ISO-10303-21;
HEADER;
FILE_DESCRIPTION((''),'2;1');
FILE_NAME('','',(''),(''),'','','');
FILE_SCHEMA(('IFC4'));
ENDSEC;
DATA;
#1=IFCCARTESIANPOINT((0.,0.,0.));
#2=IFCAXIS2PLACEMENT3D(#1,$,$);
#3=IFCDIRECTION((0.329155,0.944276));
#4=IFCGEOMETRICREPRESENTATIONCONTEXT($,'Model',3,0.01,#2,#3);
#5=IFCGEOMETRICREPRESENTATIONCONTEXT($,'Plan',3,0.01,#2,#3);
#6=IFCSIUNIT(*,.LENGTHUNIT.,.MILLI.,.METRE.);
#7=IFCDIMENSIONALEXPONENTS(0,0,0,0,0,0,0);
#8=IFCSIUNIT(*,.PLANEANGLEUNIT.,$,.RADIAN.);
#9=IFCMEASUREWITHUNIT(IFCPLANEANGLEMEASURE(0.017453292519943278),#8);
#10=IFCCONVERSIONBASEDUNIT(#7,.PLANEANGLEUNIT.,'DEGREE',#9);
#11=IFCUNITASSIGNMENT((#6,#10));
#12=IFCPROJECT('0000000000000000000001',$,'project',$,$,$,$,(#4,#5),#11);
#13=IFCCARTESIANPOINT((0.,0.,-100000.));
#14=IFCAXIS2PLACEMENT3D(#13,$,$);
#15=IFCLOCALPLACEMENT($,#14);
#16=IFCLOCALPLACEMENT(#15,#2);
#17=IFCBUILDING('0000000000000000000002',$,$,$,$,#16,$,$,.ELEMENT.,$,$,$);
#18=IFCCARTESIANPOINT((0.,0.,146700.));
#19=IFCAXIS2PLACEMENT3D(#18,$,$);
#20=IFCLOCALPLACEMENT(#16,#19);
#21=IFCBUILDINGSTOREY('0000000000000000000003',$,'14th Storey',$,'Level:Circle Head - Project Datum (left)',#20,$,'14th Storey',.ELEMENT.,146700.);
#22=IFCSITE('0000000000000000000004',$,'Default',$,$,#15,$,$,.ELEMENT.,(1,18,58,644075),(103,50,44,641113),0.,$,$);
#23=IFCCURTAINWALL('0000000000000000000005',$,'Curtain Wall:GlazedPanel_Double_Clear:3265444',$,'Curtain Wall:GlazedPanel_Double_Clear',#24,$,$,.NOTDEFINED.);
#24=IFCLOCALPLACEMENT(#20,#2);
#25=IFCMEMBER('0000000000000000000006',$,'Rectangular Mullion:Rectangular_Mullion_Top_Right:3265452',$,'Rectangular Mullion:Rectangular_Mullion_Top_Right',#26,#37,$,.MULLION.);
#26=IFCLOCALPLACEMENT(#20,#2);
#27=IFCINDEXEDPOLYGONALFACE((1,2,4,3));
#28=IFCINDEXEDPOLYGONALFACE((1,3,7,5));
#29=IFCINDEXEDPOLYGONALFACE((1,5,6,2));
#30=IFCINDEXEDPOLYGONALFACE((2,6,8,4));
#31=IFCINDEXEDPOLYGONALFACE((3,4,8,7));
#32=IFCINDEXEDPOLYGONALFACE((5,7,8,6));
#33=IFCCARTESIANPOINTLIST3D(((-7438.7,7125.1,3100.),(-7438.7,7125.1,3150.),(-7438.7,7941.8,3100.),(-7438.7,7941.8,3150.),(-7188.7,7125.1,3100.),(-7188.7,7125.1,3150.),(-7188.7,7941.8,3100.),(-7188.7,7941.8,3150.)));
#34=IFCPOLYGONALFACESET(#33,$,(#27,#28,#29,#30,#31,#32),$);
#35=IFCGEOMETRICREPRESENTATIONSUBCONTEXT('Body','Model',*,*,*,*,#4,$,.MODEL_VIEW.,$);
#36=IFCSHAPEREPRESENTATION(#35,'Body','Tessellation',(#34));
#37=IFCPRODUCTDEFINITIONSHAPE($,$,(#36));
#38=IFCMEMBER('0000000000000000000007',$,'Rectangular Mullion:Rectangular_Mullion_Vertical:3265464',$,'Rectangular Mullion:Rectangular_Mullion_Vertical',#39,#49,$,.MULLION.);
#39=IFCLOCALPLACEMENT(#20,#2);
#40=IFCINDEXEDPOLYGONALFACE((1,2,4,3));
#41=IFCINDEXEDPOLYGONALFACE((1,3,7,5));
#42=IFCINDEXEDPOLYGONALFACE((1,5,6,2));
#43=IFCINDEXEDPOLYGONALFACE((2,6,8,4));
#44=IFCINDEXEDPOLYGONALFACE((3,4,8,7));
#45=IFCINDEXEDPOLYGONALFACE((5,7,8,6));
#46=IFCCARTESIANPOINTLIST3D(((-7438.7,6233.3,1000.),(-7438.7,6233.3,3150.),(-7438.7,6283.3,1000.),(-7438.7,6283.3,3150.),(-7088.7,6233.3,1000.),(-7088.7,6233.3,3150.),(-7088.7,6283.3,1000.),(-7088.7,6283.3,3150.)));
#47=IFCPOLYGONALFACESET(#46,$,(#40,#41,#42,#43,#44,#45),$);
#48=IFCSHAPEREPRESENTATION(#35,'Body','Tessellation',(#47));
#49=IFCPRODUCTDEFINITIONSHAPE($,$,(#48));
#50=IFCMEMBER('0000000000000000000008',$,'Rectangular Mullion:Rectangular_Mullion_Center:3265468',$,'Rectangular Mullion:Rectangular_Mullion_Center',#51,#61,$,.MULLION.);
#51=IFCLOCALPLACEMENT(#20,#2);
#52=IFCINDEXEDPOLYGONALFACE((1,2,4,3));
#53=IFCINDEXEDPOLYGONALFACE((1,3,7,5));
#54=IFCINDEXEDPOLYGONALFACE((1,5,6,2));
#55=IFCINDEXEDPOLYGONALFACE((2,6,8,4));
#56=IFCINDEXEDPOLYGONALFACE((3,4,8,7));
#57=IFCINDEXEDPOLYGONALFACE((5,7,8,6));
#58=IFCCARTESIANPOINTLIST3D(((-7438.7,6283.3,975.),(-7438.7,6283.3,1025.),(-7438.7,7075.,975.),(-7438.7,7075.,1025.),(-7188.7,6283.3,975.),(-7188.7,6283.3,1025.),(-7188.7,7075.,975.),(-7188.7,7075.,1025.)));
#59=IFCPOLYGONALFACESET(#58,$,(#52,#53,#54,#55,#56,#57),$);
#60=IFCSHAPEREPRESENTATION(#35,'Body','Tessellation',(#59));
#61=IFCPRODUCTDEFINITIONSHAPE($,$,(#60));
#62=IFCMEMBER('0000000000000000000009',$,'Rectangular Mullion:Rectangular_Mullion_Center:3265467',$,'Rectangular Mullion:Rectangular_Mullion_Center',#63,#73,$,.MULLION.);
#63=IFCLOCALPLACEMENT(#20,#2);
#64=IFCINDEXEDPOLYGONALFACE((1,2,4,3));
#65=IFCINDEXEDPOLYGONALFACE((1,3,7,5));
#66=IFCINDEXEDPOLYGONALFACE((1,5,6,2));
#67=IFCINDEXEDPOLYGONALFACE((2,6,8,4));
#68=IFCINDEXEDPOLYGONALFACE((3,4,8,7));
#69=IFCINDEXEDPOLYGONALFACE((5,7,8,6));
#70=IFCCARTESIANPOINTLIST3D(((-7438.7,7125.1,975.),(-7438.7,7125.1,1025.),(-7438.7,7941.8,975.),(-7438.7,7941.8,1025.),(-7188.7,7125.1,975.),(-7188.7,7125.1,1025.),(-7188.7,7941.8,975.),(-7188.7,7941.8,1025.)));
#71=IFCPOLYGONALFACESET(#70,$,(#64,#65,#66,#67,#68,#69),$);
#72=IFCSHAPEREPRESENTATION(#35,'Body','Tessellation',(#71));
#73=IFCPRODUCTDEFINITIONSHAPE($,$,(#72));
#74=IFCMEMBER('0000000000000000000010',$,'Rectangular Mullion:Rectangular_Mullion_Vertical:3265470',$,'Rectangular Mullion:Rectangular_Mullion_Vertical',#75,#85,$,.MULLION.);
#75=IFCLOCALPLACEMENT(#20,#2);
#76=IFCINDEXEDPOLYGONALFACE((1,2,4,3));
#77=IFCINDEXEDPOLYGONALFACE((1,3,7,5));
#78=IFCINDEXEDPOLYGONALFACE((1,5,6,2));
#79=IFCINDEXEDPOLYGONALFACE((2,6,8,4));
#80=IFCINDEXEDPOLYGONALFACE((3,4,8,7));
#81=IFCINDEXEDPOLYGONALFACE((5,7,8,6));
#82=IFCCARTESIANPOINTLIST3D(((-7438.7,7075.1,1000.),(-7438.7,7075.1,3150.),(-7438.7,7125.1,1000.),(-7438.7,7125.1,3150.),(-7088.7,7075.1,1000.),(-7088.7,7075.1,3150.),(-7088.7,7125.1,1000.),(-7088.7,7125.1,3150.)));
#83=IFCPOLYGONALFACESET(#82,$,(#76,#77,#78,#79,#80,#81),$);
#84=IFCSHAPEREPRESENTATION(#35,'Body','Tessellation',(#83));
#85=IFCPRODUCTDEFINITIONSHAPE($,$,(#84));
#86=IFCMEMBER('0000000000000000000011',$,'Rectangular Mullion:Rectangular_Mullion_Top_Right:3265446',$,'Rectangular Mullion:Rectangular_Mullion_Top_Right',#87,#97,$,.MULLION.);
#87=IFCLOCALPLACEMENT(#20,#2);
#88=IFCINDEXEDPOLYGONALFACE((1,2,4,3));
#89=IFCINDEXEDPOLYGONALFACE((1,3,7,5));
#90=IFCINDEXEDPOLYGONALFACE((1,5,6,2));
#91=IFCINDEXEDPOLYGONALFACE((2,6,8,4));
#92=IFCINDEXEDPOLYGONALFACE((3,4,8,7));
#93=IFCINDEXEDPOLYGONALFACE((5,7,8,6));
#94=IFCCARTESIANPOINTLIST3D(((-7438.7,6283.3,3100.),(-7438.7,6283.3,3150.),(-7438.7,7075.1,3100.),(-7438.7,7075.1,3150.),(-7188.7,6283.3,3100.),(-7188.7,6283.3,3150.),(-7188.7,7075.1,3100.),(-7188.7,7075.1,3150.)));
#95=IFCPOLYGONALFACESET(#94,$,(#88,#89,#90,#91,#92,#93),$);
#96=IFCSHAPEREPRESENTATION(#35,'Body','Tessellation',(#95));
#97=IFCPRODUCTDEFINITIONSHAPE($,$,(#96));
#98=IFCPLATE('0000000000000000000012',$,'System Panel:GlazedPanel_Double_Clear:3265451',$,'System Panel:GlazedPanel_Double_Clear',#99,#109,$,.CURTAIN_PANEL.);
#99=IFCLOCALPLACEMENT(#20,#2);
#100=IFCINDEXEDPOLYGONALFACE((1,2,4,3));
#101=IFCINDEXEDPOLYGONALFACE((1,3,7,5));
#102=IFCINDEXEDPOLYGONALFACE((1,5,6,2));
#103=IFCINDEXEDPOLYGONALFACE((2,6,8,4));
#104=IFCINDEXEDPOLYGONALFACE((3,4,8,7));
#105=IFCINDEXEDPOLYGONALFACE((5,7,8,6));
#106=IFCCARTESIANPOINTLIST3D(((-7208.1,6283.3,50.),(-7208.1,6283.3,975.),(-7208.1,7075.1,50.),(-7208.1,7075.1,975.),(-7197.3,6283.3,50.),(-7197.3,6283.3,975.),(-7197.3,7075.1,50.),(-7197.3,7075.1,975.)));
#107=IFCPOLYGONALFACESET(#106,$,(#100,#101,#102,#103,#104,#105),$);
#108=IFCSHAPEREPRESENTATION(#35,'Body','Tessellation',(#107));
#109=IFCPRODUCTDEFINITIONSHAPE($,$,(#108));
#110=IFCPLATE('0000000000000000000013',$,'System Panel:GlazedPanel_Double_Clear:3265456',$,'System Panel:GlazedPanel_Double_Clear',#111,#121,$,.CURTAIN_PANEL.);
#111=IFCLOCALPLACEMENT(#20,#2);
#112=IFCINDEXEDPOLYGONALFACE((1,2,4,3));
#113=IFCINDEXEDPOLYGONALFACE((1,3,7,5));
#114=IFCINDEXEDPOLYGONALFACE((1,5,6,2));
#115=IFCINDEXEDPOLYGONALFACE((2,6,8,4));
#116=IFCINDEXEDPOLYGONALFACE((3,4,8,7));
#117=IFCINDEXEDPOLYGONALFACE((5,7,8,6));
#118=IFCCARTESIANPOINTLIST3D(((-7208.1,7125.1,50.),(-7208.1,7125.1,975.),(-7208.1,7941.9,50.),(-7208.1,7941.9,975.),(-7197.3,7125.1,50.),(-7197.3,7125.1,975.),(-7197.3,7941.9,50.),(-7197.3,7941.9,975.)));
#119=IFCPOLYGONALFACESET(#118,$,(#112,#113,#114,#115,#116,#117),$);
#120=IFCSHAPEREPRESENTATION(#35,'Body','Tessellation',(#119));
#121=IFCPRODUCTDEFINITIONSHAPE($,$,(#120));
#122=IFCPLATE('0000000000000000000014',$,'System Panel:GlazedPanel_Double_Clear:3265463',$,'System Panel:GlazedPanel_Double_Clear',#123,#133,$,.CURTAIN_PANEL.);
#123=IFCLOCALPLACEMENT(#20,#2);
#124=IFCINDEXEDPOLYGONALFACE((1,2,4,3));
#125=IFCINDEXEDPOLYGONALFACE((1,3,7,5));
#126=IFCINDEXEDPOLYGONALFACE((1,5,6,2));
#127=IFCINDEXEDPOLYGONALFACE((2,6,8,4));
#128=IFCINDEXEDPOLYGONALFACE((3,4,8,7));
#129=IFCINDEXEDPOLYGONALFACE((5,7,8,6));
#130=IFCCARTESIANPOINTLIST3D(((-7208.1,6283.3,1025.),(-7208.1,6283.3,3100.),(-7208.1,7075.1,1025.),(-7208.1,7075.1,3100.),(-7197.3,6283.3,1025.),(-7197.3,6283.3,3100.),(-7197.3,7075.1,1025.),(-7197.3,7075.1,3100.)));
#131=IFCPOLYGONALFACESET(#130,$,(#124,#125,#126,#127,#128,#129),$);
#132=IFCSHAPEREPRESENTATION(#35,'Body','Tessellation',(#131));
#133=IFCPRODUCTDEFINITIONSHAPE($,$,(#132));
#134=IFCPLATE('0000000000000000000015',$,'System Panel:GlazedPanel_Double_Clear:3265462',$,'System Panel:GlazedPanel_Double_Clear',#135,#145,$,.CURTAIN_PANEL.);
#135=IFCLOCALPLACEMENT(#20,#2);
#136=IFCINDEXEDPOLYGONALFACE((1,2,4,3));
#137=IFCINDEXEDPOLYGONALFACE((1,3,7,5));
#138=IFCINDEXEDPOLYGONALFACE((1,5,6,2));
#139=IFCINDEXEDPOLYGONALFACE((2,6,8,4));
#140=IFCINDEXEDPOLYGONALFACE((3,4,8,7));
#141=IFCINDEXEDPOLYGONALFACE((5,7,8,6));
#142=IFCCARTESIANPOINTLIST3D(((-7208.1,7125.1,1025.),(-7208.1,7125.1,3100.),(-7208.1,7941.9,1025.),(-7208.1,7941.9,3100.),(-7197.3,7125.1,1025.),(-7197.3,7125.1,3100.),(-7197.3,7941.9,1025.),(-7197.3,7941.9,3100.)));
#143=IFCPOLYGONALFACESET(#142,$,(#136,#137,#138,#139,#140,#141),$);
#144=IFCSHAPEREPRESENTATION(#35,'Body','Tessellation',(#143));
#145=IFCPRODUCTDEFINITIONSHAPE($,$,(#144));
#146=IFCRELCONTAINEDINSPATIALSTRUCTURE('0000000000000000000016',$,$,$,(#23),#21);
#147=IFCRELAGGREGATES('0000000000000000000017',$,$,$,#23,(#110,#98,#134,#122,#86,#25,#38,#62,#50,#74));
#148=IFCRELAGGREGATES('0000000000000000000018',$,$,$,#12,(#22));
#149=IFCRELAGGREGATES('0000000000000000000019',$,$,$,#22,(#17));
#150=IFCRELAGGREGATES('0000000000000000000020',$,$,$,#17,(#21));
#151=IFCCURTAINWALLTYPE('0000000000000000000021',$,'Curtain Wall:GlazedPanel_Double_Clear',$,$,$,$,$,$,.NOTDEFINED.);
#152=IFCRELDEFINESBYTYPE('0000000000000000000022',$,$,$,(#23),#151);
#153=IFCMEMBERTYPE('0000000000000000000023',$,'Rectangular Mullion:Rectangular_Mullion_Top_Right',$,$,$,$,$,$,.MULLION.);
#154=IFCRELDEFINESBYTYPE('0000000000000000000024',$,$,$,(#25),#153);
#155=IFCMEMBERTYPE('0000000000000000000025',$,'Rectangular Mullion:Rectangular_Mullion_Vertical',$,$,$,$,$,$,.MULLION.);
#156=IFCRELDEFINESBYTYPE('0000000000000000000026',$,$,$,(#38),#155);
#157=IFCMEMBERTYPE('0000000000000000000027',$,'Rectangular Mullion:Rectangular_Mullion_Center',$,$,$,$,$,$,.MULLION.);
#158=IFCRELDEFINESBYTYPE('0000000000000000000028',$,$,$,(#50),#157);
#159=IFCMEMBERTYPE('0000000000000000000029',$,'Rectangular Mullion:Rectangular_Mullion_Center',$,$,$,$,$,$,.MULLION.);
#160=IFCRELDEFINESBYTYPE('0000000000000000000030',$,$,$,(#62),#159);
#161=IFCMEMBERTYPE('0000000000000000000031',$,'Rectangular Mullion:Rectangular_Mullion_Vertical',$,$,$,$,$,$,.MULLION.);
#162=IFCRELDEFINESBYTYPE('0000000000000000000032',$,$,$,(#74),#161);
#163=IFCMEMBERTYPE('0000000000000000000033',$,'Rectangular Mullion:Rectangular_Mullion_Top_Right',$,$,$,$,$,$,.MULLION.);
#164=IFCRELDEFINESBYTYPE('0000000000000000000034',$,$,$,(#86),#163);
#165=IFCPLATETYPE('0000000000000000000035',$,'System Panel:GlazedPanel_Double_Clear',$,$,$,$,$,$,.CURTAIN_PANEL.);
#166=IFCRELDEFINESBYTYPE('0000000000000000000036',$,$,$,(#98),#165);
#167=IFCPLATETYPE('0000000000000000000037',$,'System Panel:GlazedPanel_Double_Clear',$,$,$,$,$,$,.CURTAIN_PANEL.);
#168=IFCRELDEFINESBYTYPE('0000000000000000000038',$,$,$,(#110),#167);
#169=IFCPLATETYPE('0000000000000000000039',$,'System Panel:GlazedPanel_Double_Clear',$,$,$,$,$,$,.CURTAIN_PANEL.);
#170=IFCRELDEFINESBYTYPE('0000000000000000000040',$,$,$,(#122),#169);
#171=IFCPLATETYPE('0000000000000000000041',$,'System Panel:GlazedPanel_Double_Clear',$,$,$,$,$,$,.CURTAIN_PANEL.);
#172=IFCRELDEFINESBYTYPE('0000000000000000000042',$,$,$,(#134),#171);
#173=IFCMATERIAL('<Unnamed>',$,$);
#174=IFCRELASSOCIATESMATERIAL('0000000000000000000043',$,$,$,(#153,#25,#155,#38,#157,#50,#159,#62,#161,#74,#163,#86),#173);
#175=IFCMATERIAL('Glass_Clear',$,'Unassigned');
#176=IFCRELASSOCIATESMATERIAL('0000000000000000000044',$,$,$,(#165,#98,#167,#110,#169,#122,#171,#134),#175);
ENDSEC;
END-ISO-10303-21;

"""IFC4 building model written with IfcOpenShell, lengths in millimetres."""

from ifc_helpers import new_model, entity, si_unit, converted_unit, direction, frame, origin, place, context, subcontext, project, spatial, indexed_curve, outline, extrude, source, transform, mapped, material, type_object, type_shapes, element, aggregate, save


model = new_model("IFC4")

# Units and contexts
model_context = context("Model", 3, precision=0.01, world=origin(), true_north=direction((0.329155, 0.944276)))
plan_context = context("Plan", 3, precision=0.01, world=origin(), true_north=direction((0.329155, 0.944276)))
body_context = subcontext(model_context, "Body", "Model", "MODEL_VIEW")
ifc_project = project(units=[si_unit("LENGTHUNIT", "METRE", prefix="MILLI"), converted_unit("PLANEANGLEUNIT", "DEGREE", entity("IfcPlaneAngleMeasure", 0.017453292519943278), si_unit("PLANEANGLEUNIT", "RADIAN"), dimensions=[0, 0, 0, 0, 0, 0, 0])], contexts=[model_context, plan_context])

# Site, building, storey
site_placement = place(None, frame((0.0, 0.0, -100000.0)))
site = spatial("IfcSite", under=ifc_project, at=site_placement, Name="Default", CompositionType="ELEMENT", RefLatitude=(1, 18, 58, 644075), RefLongitude=(103, 50, 44, 641113), RefElevation=0.0)
building_placement = place(site_placement, origin())
building = spatial("IfcBuilding", under=site, at=building_placement, CompositionType="ELEMENT")
storey_placement = place(building_placement, frame((0.0, 0.0, 146700.0)))
storey = spatial("IfcBuildingStorey", under=building, at=storey_placement, Name="14th Storey", ObjectType="Level:Circle Head - Project Datum (left)", LongName="14th Storey", CompositionType="ELEMENT", Elevation=146700.0)

# Curtain wall, members, plates
curtain_wall_type = type_object("IfcCurtainWallType", Name="Curtain Wall:GlazedPanel_Double_Clear", PredefinedType="NOTDEFINED")
curtain_wall_placement = place(storey_placement, frame((0.0, 0.0, -146700.0)))
curtain_wall = element("IfcCurtainWall", 1, at=curtain_wall_placement, inside=storey, type_object=curtain_wall_type, Name="Curtain Wall:GlazedPanel_Double_Clear:3265444", ObjectType="Curtain Wall:GlazedPanel_Double_Clear", PredefinedType="NOTDEFINED")
ifc_material_1 = material(Name="<Unnamed>")
member_type_1 = type_object("IfcMemberType", Name="Rectangular Mullion:Rectangular_Mullion_Top_Right", PredefinedType="MULLION", material=ifc_material_1)
shared_shape_1 = source(origin(), body_context, "Body", "SweptSolid", [
    extrude(outline(indexed_curve([(-25.0, -125.0), (25.0, -125.0), (25.0, 125.0), (-25.0, 125.0), (-25.0, -125.0)], self_intersect=False)), frame((-25.0, 0.0, -816.7), z_axis=(0.0, 0.0, 1.0), x_axis=(-1.0, 0.0, 0.0)), (0.0, 0.0, 1.0), 816.7),
])
type_shapes(member_type_1, [shared_shape_1])
member_1_placement = place(curtain_wall_placement, frame((-7313.7, 7125.1, 149850.0), z_axis=(0.0, -1.0, 0.0), x_axis=(0.0, 0.0, 1.0)))
member_1 = element("IfcMember", 2, at=member_1_placement, type_object=member_type_1, material=ifc_material_1, Name="Rectangular Mullion:Rectangular_Mullion_Top_Right:3265452", ObjectType="Rectangular Mullion:Rectangular_Mullion_Top_Right", PredefinedType="MULLION", context=body_context, shape_type="MappedRepresentation", body=[
    mapped(shared_shape_1, transform((0.0, 0.0, 0.0), scale=1.0)),
])
member_type_2 = type_object("IfcMemberType", Name="Rectangular Mullion:Rectangular_Mullion_Vertical", PredefinedType="MULLION", material=ifc_material_1)
shared_shape_2 = source(origin(), body_context, "Body", "SweptSolid", [
    extrude(outline(indexed_curve([(-25.0, -175.0), (25.0, -175.0), (25.0, 175.0), (-25.0, 175.0), (-25.0, -175.0)], self_intersect=False)), frame((-25.0, -50.0, -2150.0), z_axis=(0.0, 0.0, 1.0), x_axis=(-1.0, 0.0, 0.0)), (0.0, 0.0, 1.0), 2150.0),
])
type_shapes(member_type_2, [shared_shape_2])
member_2_placement = place(curtain_wall_placement, frame((-7313.7, 6233.3, 147700.0), z_axis=(0.0, 0.0, -1.0), x_axis=(0.0, -1.0, 0.0)))
member_2 = element("IfcMember", 3, at=member_2_placement, type_object=member_type_2, material=ifc_material_1, Name="Rectangular Mullion:Rectangular_Mullion_Vertical:3265464", ObjectType="Rectangular Mullion:Rectangular_Mullion_Vertical", PredefinedType="MULLION", context=body_context, shape_type="MappedRepresentation", body=[
    mapped(shared_shape_2, transform((0.0, 0.0, 0.0), scale=1.0)),
])
member_type_3 = type_object("IfcMemberType", Name="Rectangular Mullion:Rectangular_Mullion_Center", PredefinedType="MULLION", material=ifc_material_1)
shared_shape_3 = source(origin(), body_context, "Body", "SweptSolid", [
    extrude(outline(indexed_curve([(-25.0, -125.0), (25.0, -125.0), (25.0, 125.0), (-25.0, 125.0), (-25.0, -125.0)], self_intersect=False)), frame((0.0, 0.0, -791.7), z_axis=(0.0, 0.0, 1.0), x_axis=(-1.0, 0.0, 0.0)), (0.0, 0.0, 1.0), 791.7),
])
type_shapes(member_type_3, [shared_shape_3])
member_3_placement = place(curtain_wall_placement, frame((-7313.7, 6283.3, 147700.0), z_axis=(0.0, -1.0, 0.0), x_axis=(0.0, 0.0, 1.0)))
member_3 = element("IfcMember", 4, at=member_3_placement, type_object=member_type_3, material=ifc_material_1, Name="Rectangular Mullion:Rectangular_Mullion_Center:3265468", ObjectType="Rectangular Mullion:Rectangular_Mullion_Center", PredefinedType="MULLION", context=body_context, shape_type="MappedRepresentation", body=[
    mapped(shared_shape_3, transform((0.0, 0.0, 0.0), scale=1.0)),
])
member_type_4 = type_object("IfcMemberType", Name="Rectangular Mullion:Rectangular_Mullion_Center", PredefinedType="MULLION", material=ifc_material_1)
shared_shape_4 = source(origin(), body_context, "Body", "SweptSolid", [
    extrude(outline(indexed_curve([(-25.0, -125.0), (25.0, -125.0), (25.0, 125.0), (-25.0, 125.0), (-25.0, -125.0)], self_intersect=False)), frame((0.0, 0.0, -816.7), z_axis=(0.0, 0.0, 1.0), x_axis=(-1.0, 0.0, 0.0)), (0.0, 0.0, 1.0), 816.7),
])
type_shapes(member_type_4, [shared_shape_4])
member_4_placement = place(curtain_wall_placement, frame((-7313.7, 7125.1, 147700.0), z_axis=(0.0, -1.0, 0.0), x_axis=(0.0, 0.0, 1.0)))
member_4 = element("IfcMember", 5, at=member_4_placement, type_object=member_type_4, material=ifc_material_1, Name="Rectangular Mullion:Rectangular_Mullion_Center:3265467", ObjectType="Rectangular Mullion:Rectangular_Mullion_Center", PredefinedType="MULLION", context=body_context, shape_type="MappedRepresentation", body=[
    mapped(shared_shape_4, transform((0.0, 0.0, 0.0), scale=1.0)),
])
member_type_5 = type_object("IfcMemberType", Name="Rectangular Mullion:Rectangular_Mullion_Vertical", PredefinedType="MULLION", material=ifc_material_1)
shared_shape_5 = source(origin(), body_context, "Body", "SweptSolid", [
    extrude(outline(indexed_curve([(-25.0, -175.0), (25.0, -175.0), (25.0, 175.0), (-25.0, 175.0), (-25.0, -175.0)], self_intersect=False)), frame((0.0, -50.0, -2150.0), z_axis=(0.0, 0.0, 1.0), x_axis=(-1.0, 0.0, 0.0)), (0.0, 0.0, 1.0), 2150.0),
])
type_shapes(member_type_5, [shared_shape_5])
member_5_placement = place(curtain_wall_placement, frame((-7313.7, 7100.1, 147700.0), z_axis=(0.0, 0.0, -1.0), x_axis=(0.0, -1.0, 0.0)))
member_5 = element("IfcMember", 6, at=member_5_placement, type_object=member_type_5, material=ifc_material_1, Name="Rectangular Mullion:Rectangular_Mullion_Vertical:3265470", ObjectType="Rectangular Mullion:Rectangular_Mullion_Vertical", PredefinedType="MULLION", context=body_context, shape_type="MappedRepresentation", body=[
    mapped(shared_shape_5, transform((0.0, 0.0, 0.0), scale=1.0)),
])
member_type_6 = type_object("IfcMemberType", Name="Rectangular Mullion:Rectangular_Mullion_Top_Right", PredefinedType="MULLION", material=ifc_material_1)
shared_shape_6 = source(origin(), body_context, "Body", "SweptSolid", [
    extrude(outline(indexed_curve([(-25.0, -125.0), (25.0, -125.0), (25.0, 125.0), (-25.0, 125.0), (-25.0, -125.0)], self_intersect=False)), frame((-25.0, 0.0, -791.8), z_axis=(0.0, 0.0, 1.0), x_axis=(-1.0, 0.0, 0.0)), (0.0, 0.0, 1.0), 791.8),
])
type_shapes(member_type_6, [shared_shape_6])
member_6_placement = place(curtain_wall_placement, frame((-7313.7, 6283.3, 149850.0), z_axis=(0.0, -1.0, 0.0), x_axis=(0.0, 0.0, 1.0)))
member_6 = element("IfcMember", 7, at=member_6_placement, type_object=member_type_6, material=ifc_material_1, Name="Rectangular Mullion:Rectangular_Mullion_Top_Right:3265446", ObjectType="Rectangular Mullion:Rectangular_Mullion_Top_Right", PredefinedType="MULLION", context=body_context, shape_type="MappedRepresentation", body=[
    mapped(shared_shape_6, transform((0.0, 0.0, 0.0), scale=1.0)),
])
ifc_material_2 = material(Name="Glass_Clear", Category="Unassigned")
plate_type_1 = type_object("IfcPlateType", Name="System Panel:GlazedPanel_Double_Clear", PredefinedType="CURTAIN_PANEL", material=ifc_material_2)
shared_shape_7 = source(origin(), body_context, "Body", "SweptSolid", [
    extrude(outline(indexed_curve([(-5.4, -395.9), (5.4, -395.9), (5.4, 395.9), (-5.4, 395.9), (-5.4, -395.9)], self_intersect=False)), frame((395.9, 5.4, 0.0), z_axis=(0.0, 0.0, 1.0), x_axis=(0.0, 1.0, 0.0)), (0.0, 0.0, 1.0), 925.0),
])
type_shapes(plate_type_1, [shared_shape_7])
plate_1_placement = place(curtain_wall_placement, frame((-7208.1, 7075.1, 146750.0), z_axis=(0.0, 0.0, 1.0), x_axis=(0.0, -1.0, 0.0)))
plate_1 = element("IfcPlate", 8, at=plate_1_placement, type_object=plate_type_1, material=ifc_material_2, Name="System Panel:GlazedPanel_Double_Clear:3265451", ObjectType="System Panel:GlazedPanel_Double_Clear", PredefinedType="CURTAIN_PANEL", context=body_context, shape_type="MappedRepresentation", body=[
    mapped(shared_shape_7, transform((0.0, 0.0, 0.0), scale=1.0)),
])
plate_type_2 = type_object("IfcPlateType", Name="System Panel:GlazedPanel_Double_Clear", PredefinedType="CURTAIN_PANEL", material=ifc_material_2)
shared_shape_8 = source(origin(), body_context, "Body", "SweptSolid", [
    extrude(outline(indexed_curve([(-5.4, -408.4), (5.4, -408.4), (5.4, 408.4), (-5.4, 408.4), (-5.4, -408.4)], self_intersect=False)), frame((408.4, 5.4, 0.0), z_axis=(0.0, 0.0, 1.0), x_axis=(0.0, 1.0, 0.0)), (0.0, 0.0, 1.0), 925.0),
])
type_shapes(plate_type_2, [shared_shape_8])
plate_2_placement = place(curtain_wall_placement, frame((-7208.1, 7941.9, 146750.0), z_axis=(0.0, 0.0, 1.0), x_axis=(0.0, -1.0, 0.0)))
plate_2 = element("IfcPlate", 9, at=plate_2_placement, type_object=plate_type_2, material=ifc_material_2, Name="System Panel:GlazedPanel_Double_Clear:3265456", ObjectType="System Panel:GlazedPanel_Double_Clear", PredefinedType="CURTAIN_PANEL", context=body_context, shape_type="MappedRepresentation", body=[
    mapped(shared_shape_8, transform((0.0, 0.0, 0.0), scale=1.0)),
])
plate_type_3 = type_object("IfcPlateType", Name="System Panel:GlazedPanel_Double_Clear", PredefinedType="CURTAIN_PANEL", material=ifc_material_2)
shared_shape_9 = source(origin(), body_context, "Body", "SweptSolid", [
    extrude(outline(indexed_curve([(-5.4, -395.9), (5.4, -395.9), (5.4, 395.9), (-5.4, 395.9), (-5.4, -395.9)], self_intersect=False)), frame((395.9, 5.4, 0.0), z_axis=(0.0, 0.0, 1.0), x_axis=(0.0, 1.0, 0.0)), (0.0, 0.0, 1.0), 2075.0),
])
type_shapes(plate_type_3, [shared_shape_9])
plate_3_placement = place(curtain_wall_placement, frame((-7208.1, 7075.1, 147725.0), z_axis=(0.0, 0.0, 1.0), x_axis=(0.0, -1.0, 0.0)))
plate_3 = element("IfcPlate", 10, at=plate_3_placement, type_object=plate_type_3, material=ifc_material_2, Name="System Panel:GlazedPanel_Double_Clear:3265463", ObjectType="System Panel:GlazedPanel_Double_Clear", PredefinedType="CURTAIN_PANEL", context=body_context, shape_type="MappedRepresentation", body=[
    mapped(shared_shape_9, transform((0.0, 0.0, 0.0), scale=1.0)),
])
plate_type_4 = type_object("IfcPlateType", Name="System Panel:GlazedPanel_Double_Clear", PredefinedType="CURTAIN_PANEL", material=ifc_material_2)
shared_shape_10 = source(origin(), body_context, "Body", "SweptSolid", [
    extrude(outline(indexed_curve([(-5.4, -408.4), (5.4, -408.4), (5.4, 408.4), (-5.4, 408.4), (-5.4, -408.4)], self_intersect=False)), frame((408.4, 5.4, 0.0), z_axis=(0.0, 0.0, 1.0), x_axis=(0.0, 1.0, 0.0)), (0.0, 0.0, 1.0), 2075.0),
])
type_shapes(plate_type_4, [shared_shape_10])
plate_4_placement = place(curtain_wall_placement, frame((-7208.1, 7941.9, 147725.0), z_axis=(0.0, 0.0, 1.0), x_axis=(0.0, -1.0, 0.0)))
plate_4 = element("IfcPlate", 11, at=plate_4_placement, type_object=plate_type_4, material=ifc_material_2, Name="System Panel:GlazedPanel_Double_Clear:3265462", ObjectType="System Panel:GlazedPanel_Double_Clear", PredefinedType="CURTAIN_PANEL", context=body_context, shape_type="MappedRepresentation", body=[
    mapped(shared_shape_10, transform((0.0, 0.0, 0.0), scale=1.0)),
])
aggregate(curtain_wall, [plate_2, plate_1, plate_4, plate_3, member_6, member_1, member_2, member_4, member_3, member_5])

save(model, "model.ifc")
